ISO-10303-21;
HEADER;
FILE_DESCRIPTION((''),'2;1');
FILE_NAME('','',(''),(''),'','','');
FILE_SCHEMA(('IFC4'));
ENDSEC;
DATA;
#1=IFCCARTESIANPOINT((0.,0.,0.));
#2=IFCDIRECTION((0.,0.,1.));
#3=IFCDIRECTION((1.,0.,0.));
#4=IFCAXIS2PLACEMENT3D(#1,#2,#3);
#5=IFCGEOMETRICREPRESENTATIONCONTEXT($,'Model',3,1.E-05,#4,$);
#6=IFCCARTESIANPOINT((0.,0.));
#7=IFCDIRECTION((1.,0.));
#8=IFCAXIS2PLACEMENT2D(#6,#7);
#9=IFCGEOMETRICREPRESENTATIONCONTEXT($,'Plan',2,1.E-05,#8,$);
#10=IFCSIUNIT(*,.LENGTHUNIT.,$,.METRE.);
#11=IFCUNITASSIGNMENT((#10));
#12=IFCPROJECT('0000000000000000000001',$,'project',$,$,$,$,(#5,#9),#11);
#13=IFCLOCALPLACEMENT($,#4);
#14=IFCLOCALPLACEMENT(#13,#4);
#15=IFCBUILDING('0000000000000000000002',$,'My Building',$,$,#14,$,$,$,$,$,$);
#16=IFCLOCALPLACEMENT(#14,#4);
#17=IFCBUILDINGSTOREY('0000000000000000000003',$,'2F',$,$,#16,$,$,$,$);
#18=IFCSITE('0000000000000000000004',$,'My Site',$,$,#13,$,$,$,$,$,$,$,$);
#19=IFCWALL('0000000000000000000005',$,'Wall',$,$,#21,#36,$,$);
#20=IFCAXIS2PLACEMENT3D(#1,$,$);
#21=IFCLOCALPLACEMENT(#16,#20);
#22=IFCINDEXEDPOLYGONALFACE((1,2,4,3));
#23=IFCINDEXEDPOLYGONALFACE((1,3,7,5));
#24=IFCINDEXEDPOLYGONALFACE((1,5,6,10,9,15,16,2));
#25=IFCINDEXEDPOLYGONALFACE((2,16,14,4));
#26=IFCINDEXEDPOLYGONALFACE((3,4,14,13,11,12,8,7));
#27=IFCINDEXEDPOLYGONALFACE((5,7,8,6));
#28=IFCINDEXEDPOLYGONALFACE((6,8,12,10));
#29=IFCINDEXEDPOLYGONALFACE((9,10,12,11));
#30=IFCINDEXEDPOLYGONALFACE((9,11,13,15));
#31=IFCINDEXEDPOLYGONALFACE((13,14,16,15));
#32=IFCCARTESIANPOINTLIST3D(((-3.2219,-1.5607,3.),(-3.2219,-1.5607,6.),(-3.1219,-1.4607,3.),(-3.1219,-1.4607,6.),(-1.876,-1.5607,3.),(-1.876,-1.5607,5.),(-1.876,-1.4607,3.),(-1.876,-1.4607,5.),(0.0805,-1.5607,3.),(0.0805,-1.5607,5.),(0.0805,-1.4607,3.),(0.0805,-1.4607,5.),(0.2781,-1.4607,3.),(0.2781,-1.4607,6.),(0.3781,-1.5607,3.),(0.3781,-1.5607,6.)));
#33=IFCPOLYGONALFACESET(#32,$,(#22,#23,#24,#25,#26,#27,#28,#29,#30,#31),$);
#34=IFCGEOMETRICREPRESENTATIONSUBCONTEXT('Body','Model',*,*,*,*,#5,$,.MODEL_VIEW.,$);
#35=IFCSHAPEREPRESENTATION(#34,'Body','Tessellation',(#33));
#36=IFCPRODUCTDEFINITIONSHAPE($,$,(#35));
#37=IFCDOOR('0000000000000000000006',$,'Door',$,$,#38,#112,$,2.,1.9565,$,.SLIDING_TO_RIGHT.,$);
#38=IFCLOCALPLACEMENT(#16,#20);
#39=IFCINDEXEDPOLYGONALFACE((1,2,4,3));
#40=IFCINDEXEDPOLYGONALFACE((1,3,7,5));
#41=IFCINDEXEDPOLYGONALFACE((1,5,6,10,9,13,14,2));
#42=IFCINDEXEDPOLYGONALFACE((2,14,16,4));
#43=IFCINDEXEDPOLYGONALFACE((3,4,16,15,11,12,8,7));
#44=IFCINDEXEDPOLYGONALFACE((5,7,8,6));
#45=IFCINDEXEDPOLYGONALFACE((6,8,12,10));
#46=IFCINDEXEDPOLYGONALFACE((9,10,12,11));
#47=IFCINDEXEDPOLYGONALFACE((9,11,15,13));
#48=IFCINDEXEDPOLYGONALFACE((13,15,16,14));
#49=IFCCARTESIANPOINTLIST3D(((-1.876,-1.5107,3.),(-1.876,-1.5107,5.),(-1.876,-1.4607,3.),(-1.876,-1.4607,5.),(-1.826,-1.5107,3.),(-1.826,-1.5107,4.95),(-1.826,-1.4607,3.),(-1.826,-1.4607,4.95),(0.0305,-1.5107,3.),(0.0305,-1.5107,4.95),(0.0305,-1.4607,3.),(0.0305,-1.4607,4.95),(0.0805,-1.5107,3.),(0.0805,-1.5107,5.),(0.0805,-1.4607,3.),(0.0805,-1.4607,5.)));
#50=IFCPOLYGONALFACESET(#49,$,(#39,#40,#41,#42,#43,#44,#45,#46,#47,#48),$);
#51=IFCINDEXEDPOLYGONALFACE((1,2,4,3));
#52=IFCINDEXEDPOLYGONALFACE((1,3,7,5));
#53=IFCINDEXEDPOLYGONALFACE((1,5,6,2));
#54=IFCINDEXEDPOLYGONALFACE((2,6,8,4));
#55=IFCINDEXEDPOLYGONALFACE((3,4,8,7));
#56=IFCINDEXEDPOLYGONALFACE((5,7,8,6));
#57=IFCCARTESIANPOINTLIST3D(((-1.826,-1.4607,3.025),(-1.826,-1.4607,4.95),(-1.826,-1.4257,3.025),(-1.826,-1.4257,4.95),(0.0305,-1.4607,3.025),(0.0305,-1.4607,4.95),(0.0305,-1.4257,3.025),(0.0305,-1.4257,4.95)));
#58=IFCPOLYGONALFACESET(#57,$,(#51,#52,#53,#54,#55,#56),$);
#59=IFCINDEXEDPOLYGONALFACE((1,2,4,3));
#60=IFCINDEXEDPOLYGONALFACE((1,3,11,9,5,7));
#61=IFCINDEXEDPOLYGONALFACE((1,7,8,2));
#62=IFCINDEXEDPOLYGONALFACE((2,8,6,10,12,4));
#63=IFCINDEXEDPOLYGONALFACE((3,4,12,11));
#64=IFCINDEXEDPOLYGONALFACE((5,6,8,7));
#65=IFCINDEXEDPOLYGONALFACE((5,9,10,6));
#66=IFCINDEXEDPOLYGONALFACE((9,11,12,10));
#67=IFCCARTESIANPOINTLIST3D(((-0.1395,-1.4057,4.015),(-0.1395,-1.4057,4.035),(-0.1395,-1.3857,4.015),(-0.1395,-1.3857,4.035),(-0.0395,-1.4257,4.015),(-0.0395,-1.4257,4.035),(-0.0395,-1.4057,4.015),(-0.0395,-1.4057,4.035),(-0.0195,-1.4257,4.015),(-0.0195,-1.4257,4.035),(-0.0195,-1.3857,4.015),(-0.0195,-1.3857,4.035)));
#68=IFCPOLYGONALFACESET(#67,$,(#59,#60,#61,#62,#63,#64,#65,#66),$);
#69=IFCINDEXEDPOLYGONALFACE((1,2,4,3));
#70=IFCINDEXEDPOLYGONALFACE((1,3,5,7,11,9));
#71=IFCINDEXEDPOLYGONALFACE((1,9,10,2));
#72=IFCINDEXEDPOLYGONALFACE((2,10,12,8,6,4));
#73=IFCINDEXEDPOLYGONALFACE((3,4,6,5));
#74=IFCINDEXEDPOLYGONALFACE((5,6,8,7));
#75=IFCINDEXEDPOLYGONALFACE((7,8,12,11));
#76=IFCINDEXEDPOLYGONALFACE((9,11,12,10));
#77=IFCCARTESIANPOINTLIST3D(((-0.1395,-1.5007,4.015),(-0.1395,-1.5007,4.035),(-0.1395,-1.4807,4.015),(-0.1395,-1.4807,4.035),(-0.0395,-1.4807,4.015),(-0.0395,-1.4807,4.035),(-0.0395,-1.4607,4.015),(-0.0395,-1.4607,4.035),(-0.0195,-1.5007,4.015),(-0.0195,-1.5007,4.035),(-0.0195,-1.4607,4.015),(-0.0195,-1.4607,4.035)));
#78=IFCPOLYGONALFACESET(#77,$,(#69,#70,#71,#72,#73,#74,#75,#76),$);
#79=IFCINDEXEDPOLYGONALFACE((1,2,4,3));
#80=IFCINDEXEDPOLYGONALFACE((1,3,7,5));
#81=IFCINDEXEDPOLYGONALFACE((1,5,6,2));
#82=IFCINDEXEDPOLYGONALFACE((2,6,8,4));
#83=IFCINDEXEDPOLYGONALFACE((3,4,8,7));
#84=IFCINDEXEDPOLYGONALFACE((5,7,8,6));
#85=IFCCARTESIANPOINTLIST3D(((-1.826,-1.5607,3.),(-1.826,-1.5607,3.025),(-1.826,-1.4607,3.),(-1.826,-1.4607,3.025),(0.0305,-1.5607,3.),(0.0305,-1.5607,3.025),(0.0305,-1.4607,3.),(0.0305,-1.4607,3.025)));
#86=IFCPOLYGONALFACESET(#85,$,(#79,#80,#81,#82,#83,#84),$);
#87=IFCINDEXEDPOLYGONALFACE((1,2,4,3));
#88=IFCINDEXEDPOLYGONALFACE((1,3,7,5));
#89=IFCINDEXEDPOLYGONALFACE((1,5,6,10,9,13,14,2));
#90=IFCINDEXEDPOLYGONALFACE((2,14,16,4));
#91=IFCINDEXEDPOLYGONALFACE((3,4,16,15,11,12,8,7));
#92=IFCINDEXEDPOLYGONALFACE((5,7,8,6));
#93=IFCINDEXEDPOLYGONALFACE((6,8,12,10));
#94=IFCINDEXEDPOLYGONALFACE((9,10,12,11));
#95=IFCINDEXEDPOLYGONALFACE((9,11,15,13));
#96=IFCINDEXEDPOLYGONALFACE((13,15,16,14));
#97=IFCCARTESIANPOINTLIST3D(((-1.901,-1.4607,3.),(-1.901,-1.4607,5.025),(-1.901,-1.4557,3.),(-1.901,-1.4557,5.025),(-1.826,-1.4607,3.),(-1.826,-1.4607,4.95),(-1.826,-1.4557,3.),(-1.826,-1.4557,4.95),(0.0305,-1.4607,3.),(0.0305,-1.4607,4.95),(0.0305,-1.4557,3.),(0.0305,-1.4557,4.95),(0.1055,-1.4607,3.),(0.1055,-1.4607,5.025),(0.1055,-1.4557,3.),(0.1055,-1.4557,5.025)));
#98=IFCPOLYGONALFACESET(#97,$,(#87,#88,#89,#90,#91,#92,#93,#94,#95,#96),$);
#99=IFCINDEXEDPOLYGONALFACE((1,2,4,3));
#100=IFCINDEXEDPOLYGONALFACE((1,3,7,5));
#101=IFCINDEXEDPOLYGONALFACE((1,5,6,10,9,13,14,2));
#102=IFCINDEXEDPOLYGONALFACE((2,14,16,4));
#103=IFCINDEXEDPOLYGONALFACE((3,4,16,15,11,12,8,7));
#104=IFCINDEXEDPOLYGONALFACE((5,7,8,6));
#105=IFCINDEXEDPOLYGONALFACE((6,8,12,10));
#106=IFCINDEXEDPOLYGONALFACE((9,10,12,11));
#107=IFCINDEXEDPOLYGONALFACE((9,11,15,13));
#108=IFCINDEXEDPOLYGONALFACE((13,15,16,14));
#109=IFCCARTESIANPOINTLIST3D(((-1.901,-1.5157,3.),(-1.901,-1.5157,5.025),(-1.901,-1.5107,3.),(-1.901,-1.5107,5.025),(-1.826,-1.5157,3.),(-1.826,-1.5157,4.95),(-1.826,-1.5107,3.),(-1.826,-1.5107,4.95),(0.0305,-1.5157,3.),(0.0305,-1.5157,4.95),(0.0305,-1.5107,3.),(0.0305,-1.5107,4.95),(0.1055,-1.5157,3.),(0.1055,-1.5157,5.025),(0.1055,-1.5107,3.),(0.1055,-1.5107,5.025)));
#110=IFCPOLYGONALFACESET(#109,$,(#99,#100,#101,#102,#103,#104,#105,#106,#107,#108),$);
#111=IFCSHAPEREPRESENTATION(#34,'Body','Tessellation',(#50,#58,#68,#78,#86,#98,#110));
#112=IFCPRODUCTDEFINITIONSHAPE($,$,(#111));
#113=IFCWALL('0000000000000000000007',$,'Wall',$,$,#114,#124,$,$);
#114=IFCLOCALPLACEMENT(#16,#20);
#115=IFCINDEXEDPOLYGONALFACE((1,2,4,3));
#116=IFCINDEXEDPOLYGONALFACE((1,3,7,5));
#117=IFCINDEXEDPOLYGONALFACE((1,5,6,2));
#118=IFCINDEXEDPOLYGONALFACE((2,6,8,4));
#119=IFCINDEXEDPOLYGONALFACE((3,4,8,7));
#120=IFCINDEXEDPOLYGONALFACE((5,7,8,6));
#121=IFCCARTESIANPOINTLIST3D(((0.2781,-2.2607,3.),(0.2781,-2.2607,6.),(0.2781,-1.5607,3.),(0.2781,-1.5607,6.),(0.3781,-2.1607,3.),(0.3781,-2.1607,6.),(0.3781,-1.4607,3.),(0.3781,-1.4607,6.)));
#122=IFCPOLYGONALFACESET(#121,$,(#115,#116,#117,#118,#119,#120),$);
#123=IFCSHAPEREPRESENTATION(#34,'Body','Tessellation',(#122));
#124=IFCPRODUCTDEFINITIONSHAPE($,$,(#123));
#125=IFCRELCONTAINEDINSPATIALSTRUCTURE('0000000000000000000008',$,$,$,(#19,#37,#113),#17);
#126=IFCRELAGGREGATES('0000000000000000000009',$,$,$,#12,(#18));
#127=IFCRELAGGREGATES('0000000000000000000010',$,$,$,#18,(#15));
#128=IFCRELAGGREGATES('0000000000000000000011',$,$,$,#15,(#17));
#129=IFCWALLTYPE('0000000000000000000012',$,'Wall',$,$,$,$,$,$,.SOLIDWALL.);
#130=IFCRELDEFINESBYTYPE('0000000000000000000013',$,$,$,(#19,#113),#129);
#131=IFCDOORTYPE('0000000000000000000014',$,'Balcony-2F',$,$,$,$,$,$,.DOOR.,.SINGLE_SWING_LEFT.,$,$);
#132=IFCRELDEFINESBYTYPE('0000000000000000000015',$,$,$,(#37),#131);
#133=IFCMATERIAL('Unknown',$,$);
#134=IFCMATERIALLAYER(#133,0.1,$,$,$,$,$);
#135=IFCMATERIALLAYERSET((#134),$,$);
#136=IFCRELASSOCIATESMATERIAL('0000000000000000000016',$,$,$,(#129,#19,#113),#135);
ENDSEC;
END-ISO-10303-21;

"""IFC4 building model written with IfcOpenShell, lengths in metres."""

from ifc_helpers import new_model, entity, si_unit, frame, origin_with_axes, origin_2d_with_axis, place, context, subcontext, project, spatial, line, indexed_curve, outline, extrude, shape, source, transform, mapped, material, layer, layer_set, layer_usage, type_object, type_shapes, element, fill, save


model = new_model("IFC4")

# Units and contexts
model_context = context("Model", 3, precision=1e-05, world=origin_with_axes())
plan_context = context("Plan", 2, precision=1e-05, world=origin_2d_with_axis())
body_context_1 = subcontext(model_context, "Body", "Model", "MODEL_VIEW")
body_context_2 = subcontext(plan_context, "Body", "Plan", "PLAN_VIEW")
ifc_project = project(units=[si_unit("LENGTHUNIT", "METRE")], contexts=[model_context, plan_context])

# Site, building, storey
site_placement = place(None, origin_with_axes())
site = spatial("IfcSite", under=ifc_project, at=site_placement, Name="My Site")
building_placement = place(site_placement, origin_with_axes())
building = spatial("IfcBuilding", under=site, at=building_placement, Name="My Building")
storey_placement = place(building_placement, origin_with_axes())
storey = spatial("IfcBuildingStorey", under=building, at=storey_placement, Name="2F")

# Shared definitions
ifc_material = material(Name="Unknown")

# Shared definitions
ifc_layer = layer(ifc_material, 0.1)
ifc_layer_set = layer_set([ifc_layer])
wall_type = type_object("IfcWallType", Name="Wall", PredefinedType="SOLIDWALL", material=ifc_layer_set)

# Wall, opening, door
ifc_layer_usage_1 = layer_usage(ifc_layer_set, "AXIS2", "POSITIVE", 0.0)
wall_1_placement = place(storey_placement, frame((-3.2219, -1.5607, 3.0), z_axis=(0.0, 0.0, 1.0), x_axis=(1.0, 0.0, 0.0)))
wall_1 = element("IfcWall", 1, at=wall_1_placement, inside=storey, type_object=wall_type, material=ifc_layer_usage_1, Name="Wall", context=body_context_1, shape_type="SweptSolid", body=[
    extrude(outline(indexed_curve([(0.0, 0.0), (0.1, 0.1), (3.5, 0.1), (3.6, 0.0)], segments=[line(1, 2, 3, 4, 1)])), origin_with_axes(), (0.0, 0.0, 1.0), 3.0),
])
shared_shape_1 = source(origin_with_axes(), body_context_1, "Body", "SweptSolid", [
    extrude(outline(indexed_curve([(0.0, 0.0), (1.9565, 0.0), (1.9565, 2.0), (0.0, 2.0)], segments=[line(1, 2, 3, 4, 1)])), frame((0.0, -0.6, 0.0), z_axis=(0.0, -1.0, 0.0), x_axis=(1.0, 0.0, 0.0)), (0.0, 0.0, -1.0), 1.2),
])
opening_1_placement = place(wall_1_placement, frame((3.3023, 0.1, 0.0), z_axis=(0.0, 0.0, 1.0), x_axis=(-1.0, 0.0, 0.0)))
opening_1 = element("IfcOpeningElement", 2, at=opening_1_placement, cuts=wall_1, PredefinedType="OPENING", context=body_context_1, shape_type="MappedRepresentation", body=[
    mapped(shared_shape_1, transform((0.0, 0.0, 0.0), x_axis=(1.0, 0.0, 0.0), y_axis=(0.0, 1.0, 0.0), z_axis=(0.0, 0.0, 1.0), scale=1.0)),
])
door_type_1 = type_object("IfcDoorType", Name="Balcony-2F", OperationType="SINGLE_SWING_LEFT", PredefinedType="DOOR")
shared_shape_2 = source(origin_with_axes(), body_context_1, "Body", "SweptSolid", [
    extrude(outline(indexed_curve([(0.0, 0.0), (0.0, 2.0), (1.9565, 2.0), (1.9565, 0.0), (1.9065, 0.0), (1.9065, 1.95), (0.05, 1.95), (0.05, 0.0)], segments=[line(1, 2, 3, 4, 5, 6, 7, 8, 1)])), frame((0.0, 0.0, 0.0), z_axis=(0.0, -1.0, 0.0), x_axis=(1.0, 0.0, 0.0)), (0.0, 0.0, -1.0), 0.05),
    extrude(outline(indexed_curve([(0.0, 0.0), (1.8565, 0.0), (1.8565, 0.035), (0.0, 0.035)], segments=[line(1, 2, 3, 4, 1)])), frame((0.05, -0.035, 0.025), z_axis=(0.0, 0.0, 1.0), x_axis=(1.0, 0.0, 0.0)), (0.0, 0.0, 1.0), 1.925),
    extrude(outline(indexed_curve([(0.0, 0.0), (0.0, -0.04), (0.12, -0.04), (0.12, -0.02), (0.02, -0.02), (0.02, 0.0)], segments=[line(1, 2, 3, 4, 5, 6, 1)])), frame((0.1, -0.035, 1.015), z_axis=(0.0, 0.0, 1.0), x_axis=(1.0, 0.0, 0.0)), (0.0, 0.0, 1.0), 0.02),
    extrude(outline(indexed_curve([(0.0, 0.0), (0.0, 0.04), (0.12, 0.04), (0.12, 0.02), (0.02, 0.02), (0.02, 0.0)], segments=[line(1, 2, 3, 4, 5, 6, 1)])), frame((0.1, 0.0, 1.015), z_axis=(0.0, 0.0, 1.0), x_axis=(1.0, 0.0, 0.0)), (0.0, 0.0, 1.0), 0.02),
    extrude(outline(indexed_curve([(0.0, 0.0), (1.8565, 0.0), (1.8565, 0.1), (0.0, 0.1)], segments=[line(1, 2, 3, 4, 1)])), frame((0.05, 0.0, 0.0), z_axis=(0.0, 0.0, 1.0), x_axis=(1.0, 0.0, 0.0)), (0.0, 0.0, 1.0), 0.025),
    extrude(outline(indexed_curve([(0.0, 0.0), (0.0, 2.025), (2.0065, 2.025), (2.0065, 0.0), (1.9315, 0.0), (1.9315, 1.95), (0.075, 1.95), (0.075, 0.0)], segments=[line(1, 2, 3, 4, 5, 6, 7, 8, 1)])), frame((-0.025, -0.005, 0.0), z_axis=(0.0, -1.0, 0.0), x_axis=(1.0, 0.0, 0.0)), (0.0, 0.0, -1.0), 0.005),
    extrude(outline(indexed_curve([(0.0, 0.0), (0.0, 2.025), (2.0065, 2.025), (2.0065, 0.0), (1.9315, 0.0), (1.9315, 1.95), (0.075, 1.95), (0.075, 0.0)], segments=[line(1, 2, 3, 4, 5, 6, 7, 8, 1)])), frame((-0.025, 0.05, 0.0), z_axis=(0.0, -1.0, 0.0), x_axis=(1.0, 0.0, 0.0)), (0.0, 0.0, -1.0), 0.005),
])
shared_shape_3 = source(origin_with_axes(), body_context_2, "Body", "Curve2D", [
    entity("IfcIndexedPolyCurve", entity("IfcCartesianPointList2D", [[0.0, 0.0], [0.05, 0.0], [0.05, 0.05], [0.0, 0.05]]), [entity("IfcLineIndex", [1, 2, 3, 4, 1])]),
    entity("IfcIndexedPolyCurve", entity("IfcCartesianPointList2D", [[1.9565, 0.0], [1.9065, 0.0], [1.9065, 0.05], [1.9565, 0.05]]), [entity("IfcLineIndex", [1, 2, 3, 4, 1])]),
    entity("IfcIndexedPolyCurve", entity("IfcCartesianPointList2D", [[2.8347, -0.035], [0.9782, -0.035], [0.9782, 0.0], [2.8347, 0.0]]), [entity("IfcLineIndex", [1, 2, 3, 4, 1])]),
])
type_shapes(door_type_1, [shared_shape_2, shared_shape_3])
door_1_placement = place(opening_1_placement, origin_with_axes())
door_1 = element("IfcDoor", 3, at=door_1_placement, inside=storey, type_object=door_type_1, Name="Door", OperationType="SLIDING_TO_RIGHT", OverallHeight=2.0, OverallWidth=1.9565, shapes=[
    shape(body_context_1, "Body", "MappedRepresentation", [mapped(shared_shape_2, transform((0.0, 0.0, 0.0), x_axis=(1.0, 0.0, 0.0), y_axis=(0.0, 1.0, 0.0), z_axis=(0.0, 0.0, 1.0), scale=1.0))]),
    shape(body_context_2, "Body", "MappedRepresentation", [mapped(shared_shape_3, transform((0.0, 0.0, 0.0), x_axis=(1.0, 0.0, 0.0), y_axis=(0.0, 1.0, 0.0), z_axis=(0.0, 0.0, 1.0), scale=1.0))]),
])
fill(opening_1, door_1)

# Wall
ifc_layer_usage_2 = layer_usage(ifc_layer_set, "AXIS2", "POSITIVE", 0.0)
wall_2_placement = place(storey_placement, frame((0.2781, -1.5607, 3.0), z_axis=(0.0, 0.0, 1.0), x_axis=(0.0, -1.0, 0.0)))
element("IfcWall", 4, at=wall_2_placement, inside=storey, type_object=wall_type, material=ifc_layer_usage_2, Name="Wall", context=body_context_1, shape_type="SweptSolid", body=[
    extrude(outline(indexed_curve([(0.0, 0.0), (-0.1, 0.1), (0.6, 0.1), (0.7, 0.0)], segments=[line(1, 2, 3, 4, 1)])), origin_with_axes(), (0.0, 0.0, 1.0), 3.0),
])

save(model, "model.ifc")
